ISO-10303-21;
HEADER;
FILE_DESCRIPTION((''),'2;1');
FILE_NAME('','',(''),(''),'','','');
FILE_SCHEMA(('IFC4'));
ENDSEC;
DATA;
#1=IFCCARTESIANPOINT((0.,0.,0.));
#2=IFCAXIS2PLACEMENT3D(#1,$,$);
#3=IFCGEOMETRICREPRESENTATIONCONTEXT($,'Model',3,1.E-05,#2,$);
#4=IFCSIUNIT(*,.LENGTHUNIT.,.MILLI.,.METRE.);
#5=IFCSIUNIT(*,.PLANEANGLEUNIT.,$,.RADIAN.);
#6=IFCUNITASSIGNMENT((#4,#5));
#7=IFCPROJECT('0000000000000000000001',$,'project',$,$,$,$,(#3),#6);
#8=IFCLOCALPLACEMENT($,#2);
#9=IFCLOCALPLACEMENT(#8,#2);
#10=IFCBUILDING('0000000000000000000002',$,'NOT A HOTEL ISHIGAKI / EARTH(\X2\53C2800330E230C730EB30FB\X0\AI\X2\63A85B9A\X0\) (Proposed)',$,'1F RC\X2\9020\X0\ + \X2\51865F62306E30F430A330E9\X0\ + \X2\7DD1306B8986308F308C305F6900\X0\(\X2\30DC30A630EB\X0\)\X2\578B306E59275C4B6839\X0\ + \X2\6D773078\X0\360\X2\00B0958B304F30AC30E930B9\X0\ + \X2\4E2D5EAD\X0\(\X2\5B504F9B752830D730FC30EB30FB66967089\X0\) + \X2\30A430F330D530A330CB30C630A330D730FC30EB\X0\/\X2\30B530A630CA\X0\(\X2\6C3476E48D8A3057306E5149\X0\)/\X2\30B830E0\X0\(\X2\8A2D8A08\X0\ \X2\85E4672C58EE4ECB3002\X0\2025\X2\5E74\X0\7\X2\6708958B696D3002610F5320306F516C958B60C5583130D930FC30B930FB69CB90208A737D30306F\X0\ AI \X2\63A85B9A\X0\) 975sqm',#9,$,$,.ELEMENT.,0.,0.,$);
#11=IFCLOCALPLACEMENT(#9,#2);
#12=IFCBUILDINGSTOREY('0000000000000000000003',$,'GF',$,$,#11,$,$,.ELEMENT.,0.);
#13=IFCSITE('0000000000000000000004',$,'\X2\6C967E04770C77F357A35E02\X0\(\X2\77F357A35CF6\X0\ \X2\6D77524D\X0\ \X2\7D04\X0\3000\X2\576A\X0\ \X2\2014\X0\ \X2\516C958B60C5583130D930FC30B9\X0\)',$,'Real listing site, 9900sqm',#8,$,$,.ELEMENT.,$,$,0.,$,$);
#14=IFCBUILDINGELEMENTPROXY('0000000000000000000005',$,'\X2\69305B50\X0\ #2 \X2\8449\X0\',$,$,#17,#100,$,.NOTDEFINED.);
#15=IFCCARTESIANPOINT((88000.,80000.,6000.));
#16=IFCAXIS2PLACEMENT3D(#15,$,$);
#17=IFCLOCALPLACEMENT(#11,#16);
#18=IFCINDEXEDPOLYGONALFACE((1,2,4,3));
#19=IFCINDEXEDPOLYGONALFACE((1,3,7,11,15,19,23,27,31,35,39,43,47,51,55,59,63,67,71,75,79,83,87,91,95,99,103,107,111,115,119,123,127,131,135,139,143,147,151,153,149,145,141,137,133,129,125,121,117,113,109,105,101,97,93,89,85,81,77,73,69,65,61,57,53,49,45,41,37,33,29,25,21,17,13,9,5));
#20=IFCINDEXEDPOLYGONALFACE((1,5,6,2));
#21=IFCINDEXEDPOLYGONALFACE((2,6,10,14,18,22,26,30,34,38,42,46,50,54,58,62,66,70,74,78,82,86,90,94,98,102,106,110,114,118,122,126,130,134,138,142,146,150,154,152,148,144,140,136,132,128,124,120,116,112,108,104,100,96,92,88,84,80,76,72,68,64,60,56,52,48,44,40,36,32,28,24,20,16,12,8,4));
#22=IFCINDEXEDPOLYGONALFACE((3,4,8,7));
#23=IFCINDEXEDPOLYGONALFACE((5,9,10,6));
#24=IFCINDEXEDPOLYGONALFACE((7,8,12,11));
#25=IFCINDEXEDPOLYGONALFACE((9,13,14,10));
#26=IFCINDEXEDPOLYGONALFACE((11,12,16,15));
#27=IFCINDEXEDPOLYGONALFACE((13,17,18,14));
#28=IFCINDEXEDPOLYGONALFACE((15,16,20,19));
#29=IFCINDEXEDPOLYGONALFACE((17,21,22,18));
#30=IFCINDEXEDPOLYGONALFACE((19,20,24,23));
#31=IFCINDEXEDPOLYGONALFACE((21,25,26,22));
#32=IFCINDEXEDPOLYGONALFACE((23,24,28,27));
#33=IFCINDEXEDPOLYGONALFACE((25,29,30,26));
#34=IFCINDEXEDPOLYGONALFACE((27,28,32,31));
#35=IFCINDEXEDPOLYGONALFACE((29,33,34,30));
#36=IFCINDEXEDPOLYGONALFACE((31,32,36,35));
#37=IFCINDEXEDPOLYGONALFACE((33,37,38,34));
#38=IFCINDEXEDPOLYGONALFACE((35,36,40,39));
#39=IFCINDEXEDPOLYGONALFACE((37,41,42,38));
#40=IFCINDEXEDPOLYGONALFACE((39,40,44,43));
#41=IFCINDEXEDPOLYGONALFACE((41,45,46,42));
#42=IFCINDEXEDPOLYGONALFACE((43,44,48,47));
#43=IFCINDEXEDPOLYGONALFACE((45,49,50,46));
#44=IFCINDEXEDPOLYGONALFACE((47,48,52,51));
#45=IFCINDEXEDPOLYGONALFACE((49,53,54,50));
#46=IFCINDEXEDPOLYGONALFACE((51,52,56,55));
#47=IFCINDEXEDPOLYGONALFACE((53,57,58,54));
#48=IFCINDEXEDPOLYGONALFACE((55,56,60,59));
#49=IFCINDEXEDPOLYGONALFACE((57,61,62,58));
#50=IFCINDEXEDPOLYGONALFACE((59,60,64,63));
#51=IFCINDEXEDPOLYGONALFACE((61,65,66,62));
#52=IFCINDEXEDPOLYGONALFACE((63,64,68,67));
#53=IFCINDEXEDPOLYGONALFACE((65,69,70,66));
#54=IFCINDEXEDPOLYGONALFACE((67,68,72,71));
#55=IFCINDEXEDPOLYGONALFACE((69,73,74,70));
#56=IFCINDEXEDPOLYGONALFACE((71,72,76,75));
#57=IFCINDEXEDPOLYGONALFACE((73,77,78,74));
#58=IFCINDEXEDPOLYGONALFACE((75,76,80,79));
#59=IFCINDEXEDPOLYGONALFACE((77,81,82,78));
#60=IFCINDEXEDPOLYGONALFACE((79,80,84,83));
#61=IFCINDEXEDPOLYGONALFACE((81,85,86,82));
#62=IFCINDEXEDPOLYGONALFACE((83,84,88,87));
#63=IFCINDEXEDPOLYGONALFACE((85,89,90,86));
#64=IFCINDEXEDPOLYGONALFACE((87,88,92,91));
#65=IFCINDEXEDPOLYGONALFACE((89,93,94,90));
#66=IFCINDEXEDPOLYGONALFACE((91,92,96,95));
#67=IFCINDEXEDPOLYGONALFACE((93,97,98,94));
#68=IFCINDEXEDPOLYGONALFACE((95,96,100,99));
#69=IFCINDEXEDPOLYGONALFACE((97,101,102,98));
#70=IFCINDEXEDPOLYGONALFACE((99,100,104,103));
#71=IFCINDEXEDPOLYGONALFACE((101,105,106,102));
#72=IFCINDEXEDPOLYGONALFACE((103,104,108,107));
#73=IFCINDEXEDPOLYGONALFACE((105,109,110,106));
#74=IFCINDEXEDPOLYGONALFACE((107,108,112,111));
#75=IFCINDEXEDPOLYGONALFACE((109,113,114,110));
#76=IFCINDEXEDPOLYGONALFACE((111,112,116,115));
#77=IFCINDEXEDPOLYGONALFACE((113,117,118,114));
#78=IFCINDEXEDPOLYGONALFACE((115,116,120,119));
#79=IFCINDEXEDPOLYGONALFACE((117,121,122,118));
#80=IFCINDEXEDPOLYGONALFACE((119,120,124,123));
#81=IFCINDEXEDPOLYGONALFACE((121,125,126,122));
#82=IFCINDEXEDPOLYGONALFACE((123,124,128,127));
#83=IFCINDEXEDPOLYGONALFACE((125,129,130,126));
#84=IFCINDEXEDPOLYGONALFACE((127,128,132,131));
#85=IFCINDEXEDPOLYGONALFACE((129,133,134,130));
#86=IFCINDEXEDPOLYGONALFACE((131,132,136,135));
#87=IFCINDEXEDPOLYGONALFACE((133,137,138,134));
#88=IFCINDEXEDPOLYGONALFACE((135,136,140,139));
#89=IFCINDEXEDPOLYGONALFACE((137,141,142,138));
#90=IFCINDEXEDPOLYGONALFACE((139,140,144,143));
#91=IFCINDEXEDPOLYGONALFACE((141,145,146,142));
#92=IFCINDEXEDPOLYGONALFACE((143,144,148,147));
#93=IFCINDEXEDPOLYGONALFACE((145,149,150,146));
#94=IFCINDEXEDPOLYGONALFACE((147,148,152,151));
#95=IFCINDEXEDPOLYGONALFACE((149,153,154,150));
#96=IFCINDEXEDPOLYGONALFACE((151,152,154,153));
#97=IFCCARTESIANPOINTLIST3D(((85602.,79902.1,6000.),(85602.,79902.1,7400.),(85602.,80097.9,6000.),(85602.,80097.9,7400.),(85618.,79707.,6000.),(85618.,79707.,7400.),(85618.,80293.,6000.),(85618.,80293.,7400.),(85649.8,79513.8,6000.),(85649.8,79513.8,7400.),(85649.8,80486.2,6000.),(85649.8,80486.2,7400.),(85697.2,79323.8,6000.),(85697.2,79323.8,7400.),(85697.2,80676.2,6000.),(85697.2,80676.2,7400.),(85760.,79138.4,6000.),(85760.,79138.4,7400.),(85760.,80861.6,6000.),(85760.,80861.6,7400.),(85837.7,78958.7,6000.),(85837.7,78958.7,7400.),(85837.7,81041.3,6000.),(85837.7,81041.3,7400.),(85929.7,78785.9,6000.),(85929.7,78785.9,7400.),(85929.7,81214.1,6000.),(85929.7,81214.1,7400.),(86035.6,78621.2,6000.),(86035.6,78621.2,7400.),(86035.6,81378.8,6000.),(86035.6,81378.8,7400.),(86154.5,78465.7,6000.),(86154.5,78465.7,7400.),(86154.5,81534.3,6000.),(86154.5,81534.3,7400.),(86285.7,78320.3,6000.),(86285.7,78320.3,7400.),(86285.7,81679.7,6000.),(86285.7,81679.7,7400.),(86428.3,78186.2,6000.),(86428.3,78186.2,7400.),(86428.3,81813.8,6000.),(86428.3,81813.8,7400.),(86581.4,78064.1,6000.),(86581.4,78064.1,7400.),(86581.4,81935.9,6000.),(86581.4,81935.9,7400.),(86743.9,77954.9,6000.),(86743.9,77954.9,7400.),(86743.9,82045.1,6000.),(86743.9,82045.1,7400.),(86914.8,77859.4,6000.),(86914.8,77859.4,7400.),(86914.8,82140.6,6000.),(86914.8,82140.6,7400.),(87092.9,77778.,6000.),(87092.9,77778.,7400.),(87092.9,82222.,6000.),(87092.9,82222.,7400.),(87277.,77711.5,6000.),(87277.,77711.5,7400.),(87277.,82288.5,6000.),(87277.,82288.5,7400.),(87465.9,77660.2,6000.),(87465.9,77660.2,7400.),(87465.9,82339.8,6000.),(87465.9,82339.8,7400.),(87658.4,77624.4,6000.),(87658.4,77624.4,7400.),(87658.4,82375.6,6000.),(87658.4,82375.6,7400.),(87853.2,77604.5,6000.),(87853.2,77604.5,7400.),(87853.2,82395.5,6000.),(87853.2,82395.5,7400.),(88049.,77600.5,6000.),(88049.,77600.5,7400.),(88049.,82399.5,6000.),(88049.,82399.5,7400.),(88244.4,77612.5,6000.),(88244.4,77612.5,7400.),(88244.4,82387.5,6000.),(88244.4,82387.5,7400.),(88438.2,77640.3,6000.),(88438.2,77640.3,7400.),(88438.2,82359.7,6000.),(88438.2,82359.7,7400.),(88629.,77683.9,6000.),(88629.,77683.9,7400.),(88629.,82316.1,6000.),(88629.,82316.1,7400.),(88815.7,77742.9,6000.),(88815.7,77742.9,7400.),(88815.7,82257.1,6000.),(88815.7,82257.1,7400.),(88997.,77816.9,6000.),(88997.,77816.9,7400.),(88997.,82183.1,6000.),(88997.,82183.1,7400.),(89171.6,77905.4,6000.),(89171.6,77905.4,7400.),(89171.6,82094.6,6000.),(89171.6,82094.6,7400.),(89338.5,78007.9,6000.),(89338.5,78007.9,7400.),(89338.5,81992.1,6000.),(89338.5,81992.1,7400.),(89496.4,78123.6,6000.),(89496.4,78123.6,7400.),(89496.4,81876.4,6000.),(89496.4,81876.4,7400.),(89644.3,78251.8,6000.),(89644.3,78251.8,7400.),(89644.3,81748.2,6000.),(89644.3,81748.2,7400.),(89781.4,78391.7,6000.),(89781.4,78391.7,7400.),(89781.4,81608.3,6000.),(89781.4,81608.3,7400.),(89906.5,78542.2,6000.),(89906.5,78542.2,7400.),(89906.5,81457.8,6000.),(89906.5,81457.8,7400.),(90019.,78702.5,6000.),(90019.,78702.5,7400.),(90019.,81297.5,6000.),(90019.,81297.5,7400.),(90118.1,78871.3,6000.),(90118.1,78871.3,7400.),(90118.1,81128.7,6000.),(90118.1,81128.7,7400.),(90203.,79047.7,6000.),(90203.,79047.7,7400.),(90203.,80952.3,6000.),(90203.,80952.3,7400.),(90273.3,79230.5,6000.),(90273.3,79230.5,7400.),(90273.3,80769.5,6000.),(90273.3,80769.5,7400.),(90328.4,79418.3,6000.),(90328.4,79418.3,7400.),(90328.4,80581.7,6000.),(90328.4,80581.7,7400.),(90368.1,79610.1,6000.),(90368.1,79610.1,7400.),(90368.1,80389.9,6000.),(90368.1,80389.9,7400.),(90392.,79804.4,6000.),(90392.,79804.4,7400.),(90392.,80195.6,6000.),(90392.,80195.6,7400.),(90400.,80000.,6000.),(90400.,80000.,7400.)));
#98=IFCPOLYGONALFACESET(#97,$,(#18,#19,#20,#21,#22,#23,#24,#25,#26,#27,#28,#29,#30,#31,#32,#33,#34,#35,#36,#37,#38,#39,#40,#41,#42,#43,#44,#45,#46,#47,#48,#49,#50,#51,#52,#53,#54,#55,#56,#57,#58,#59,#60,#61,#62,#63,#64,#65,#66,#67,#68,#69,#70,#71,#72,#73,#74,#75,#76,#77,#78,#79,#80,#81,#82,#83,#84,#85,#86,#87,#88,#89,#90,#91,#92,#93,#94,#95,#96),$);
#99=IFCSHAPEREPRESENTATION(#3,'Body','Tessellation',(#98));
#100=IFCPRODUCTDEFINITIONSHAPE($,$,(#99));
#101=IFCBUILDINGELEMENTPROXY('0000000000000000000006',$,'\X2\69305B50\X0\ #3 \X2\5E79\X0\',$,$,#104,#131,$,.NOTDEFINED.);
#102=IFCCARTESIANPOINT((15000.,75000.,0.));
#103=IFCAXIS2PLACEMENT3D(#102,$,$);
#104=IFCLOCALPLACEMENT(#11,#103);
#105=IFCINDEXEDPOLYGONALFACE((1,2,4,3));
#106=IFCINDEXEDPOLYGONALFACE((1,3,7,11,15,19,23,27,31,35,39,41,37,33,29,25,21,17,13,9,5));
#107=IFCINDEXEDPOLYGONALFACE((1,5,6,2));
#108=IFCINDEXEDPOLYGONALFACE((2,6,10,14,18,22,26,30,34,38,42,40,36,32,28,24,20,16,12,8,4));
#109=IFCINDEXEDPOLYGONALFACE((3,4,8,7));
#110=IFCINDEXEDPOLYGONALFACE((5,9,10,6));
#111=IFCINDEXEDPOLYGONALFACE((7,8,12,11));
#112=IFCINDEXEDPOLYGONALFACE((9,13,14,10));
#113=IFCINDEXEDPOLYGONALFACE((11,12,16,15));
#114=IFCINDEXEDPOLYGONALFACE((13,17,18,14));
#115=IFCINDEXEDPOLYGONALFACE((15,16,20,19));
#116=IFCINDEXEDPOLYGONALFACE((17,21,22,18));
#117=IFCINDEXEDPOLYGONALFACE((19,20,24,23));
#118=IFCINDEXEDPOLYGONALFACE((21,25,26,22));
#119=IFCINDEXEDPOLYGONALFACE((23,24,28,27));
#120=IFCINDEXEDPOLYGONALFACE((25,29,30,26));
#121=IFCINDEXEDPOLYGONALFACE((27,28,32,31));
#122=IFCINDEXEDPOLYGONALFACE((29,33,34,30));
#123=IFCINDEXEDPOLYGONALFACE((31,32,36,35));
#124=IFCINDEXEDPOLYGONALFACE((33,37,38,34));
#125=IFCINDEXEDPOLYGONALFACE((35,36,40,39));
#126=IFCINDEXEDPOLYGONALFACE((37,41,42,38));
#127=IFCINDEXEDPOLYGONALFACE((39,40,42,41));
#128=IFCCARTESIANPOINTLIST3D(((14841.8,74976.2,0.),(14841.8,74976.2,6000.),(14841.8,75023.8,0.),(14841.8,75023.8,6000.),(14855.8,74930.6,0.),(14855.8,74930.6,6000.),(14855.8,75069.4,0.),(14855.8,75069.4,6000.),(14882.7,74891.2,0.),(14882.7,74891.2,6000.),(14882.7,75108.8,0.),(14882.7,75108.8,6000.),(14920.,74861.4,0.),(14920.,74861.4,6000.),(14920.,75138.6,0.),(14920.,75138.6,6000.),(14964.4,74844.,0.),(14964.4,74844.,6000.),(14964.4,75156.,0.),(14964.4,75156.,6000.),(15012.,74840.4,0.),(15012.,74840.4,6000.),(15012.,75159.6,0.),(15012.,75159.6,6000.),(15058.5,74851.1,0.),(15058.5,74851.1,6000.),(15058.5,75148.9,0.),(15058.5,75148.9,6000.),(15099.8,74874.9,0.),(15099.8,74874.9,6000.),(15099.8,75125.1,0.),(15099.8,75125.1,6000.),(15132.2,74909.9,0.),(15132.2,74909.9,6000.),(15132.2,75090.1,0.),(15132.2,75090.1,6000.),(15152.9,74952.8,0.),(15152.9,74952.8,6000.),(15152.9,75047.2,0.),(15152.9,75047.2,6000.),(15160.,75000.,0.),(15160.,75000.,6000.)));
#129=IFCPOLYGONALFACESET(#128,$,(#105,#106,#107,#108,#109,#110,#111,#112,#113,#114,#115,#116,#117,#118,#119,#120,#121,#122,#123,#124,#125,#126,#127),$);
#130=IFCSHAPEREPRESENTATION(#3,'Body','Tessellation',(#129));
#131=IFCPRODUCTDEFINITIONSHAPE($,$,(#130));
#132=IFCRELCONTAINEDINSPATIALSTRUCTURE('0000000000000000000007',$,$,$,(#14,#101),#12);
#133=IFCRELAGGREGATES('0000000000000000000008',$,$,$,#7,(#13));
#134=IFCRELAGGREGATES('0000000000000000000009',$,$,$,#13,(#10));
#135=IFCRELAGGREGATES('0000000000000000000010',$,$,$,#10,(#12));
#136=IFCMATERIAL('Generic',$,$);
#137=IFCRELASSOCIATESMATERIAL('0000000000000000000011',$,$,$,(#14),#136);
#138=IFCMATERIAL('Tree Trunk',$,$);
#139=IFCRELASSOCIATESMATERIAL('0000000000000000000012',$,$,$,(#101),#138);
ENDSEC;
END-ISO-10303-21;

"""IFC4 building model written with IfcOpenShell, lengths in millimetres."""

from ifc_helpers import new_model, si_unit, frame, origin, origin_2d, place, context, project, spatial, circle, extrude, material, element, save


model = new_model("IFC4")

# Units and contexts
model_context = context("Model", 3, precision=1e-05, world=origin())
ifc_project = project(units=[si_unit("LENGTHUNIT", "METRE", prefix="MILLI"), si_unit("PLANEANGLEUNIT", "RADIAN")], contexts=[model_context])

# Site, building, storey
site_placement = place(None, origin())
site = spatial("IfcSite", under=ifc_project, at=site_placement, Name="沖縄県石垣市(石垣島 海前 約3000坪 — 公開情報ベース)", ObjectType="Real listing site, 9900sqm", CompositionType="ELEMENT", RefElevation=0.0)
building_placement = place(site_placement, origin())
building = spatial("IfcBuilding", under=site, at=building_placement, Name="NOT A HOTEL ISHIGAKI / EARTH(参考モデル・AI推定) (Proposed)", ObjectType="1F RC造 + 円形のヴィラ + 緑に覆われた椀(ボウル)型の大屋根 + 海へ360°開くガラス + 中庭(子供用プール・暖炉) + インフィニティプール/サウナ(水盤越しの光)/ジム(設計 藤本壮介。2025年7月開業。意匠は公開情報ベース・構造詳細は AI 推定) 975sqm", CompositionType="ELEMENT", ElevationOfRefHeight=0.0, ElevationOfTerrain=0.0)
storey_placement = place(building_placement, origin())
storey = spatial("IfcBuildingStorey", under=building, at=storey_placement, Name="GF", CompositionType="ELEMENT", Elevation=0.0)

# Shared definitions
ifc_material_1 = material(Name="Generic")

# Building element proxies
ifc_material_2 = material(Name="Tree Trunk")
proxy_1_placement = place(storey_placement, frame((88000.0, 80000.0, 6000.0)))
element("IfcBuildingElementProxy", 1, at=proxy_1_placement, inside=storey, material=ifc_material_1, Name="椰子 #2 葉", PredefinedType="NOTDEFINED", context=model_context, shape_type="SweptSolid", body=[
    extrude(circle(Radius=2400.0, at=origin_2d()), frame((88000.0, 80000.0, 6000.0)), (0.0, 0.0, 1.0), 1400.0),
])
proxy_2_placement = place(storey_placement, frame((15000.0, 75000.0, 0.0)))
element("IfcBuildingElementProxy", 2, at=proxy_2_placement, inside=storey, material=ifc_material_2, Name="椰子 #3 幹", PredefinedType="NOTDEFINED", context=model_context, shape_type="SweptSolid", body=[
    extrude(circle(Radius=160.0, at=origin_2d()), frame((15000.0, 75000.0, 0.0)), (0.0, 0.0, 1.0), 6000.0),
])

save(model, "model.ifc")
